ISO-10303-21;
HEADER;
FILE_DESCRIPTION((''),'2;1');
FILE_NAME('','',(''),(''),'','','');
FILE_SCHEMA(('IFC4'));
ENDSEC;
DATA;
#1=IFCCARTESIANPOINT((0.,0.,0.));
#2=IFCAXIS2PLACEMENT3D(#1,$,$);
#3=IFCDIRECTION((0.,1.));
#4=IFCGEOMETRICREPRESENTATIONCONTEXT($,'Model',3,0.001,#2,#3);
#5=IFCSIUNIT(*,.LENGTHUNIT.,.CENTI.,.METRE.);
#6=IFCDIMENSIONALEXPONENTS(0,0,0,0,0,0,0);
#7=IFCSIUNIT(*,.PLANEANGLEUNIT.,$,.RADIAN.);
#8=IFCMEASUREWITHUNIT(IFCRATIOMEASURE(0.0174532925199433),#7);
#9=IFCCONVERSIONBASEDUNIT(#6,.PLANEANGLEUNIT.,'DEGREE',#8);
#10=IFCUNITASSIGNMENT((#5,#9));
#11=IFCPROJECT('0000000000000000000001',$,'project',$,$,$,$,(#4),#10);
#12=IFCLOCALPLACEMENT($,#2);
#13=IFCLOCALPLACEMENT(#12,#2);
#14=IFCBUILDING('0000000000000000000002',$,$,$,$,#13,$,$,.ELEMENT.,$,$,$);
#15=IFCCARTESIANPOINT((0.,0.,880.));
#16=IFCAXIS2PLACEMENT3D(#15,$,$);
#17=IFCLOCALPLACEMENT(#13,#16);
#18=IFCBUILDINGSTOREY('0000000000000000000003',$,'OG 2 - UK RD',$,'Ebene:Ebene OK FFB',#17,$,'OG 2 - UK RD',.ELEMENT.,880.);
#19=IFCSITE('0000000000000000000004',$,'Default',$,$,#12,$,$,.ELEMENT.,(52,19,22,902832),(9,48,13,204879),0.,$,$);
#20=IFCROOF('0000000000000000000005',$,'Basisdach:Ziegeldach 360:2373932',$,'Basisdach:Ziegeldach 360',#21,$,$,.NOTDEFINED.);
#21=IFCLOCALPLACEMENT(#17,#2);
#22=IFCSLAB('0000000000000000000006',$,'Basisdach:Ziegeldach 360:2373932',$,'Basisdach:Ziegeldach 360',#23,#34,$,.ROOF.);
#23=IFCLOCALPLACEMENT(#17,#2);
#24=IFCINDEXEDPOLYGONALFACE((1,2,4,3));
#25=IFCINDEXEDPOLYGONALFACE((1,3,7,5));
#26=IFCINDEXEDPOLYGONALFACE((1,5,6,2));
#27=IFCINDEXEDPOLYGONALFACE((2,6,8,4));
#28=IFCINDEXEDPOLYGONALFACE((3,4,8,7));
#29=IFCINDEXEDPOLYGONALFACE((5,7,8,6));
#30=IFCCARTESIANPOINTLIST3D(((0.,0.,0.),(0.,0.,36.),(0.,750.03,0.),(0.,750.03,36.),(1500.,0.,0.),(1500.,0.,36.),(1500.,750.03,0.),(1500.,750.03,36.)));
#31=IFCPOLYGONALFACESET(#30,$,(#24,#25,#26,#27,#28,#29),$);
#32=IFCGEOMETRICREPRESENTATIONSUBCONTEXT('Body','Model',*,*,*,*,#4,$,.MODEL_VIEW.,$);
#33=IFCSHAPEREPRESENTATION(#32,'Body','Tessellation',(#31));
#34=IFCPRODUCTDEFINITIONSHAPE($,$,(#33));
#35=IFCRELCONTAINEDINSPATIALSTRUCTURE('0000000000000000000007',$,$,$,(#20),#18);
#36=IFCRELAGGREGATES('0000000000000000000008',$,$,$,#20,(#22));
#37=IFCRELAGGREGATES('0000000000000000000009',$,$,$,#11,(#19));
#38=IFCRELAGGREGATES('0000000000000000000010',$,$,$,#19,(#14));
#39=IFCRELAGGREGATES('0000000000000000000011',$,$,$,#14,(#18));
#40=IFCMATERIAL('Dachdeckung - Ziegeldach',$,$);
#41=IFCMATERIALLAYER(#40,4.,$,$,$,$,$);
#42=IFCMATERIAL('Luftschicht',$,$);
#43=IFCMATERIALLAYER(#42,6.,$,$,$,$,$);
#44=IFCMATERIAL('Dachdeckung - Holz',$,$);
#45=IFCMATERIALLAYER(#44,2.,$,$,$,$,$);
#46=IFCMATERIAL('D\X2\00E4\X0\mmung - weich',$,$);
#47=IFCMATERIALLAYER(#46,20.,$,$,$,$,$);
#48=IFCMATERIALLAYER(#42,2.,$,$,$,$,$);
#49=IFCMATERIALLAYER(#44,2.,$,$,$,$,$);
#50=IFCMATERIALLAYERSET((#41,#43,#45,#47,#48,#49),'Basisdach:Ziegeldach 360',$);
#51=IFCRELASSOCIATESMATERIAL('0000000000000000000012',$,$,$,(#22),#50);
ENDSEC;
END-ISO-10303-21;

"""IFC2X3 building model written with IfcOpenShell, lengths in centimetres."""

from ifc_helpers import new_model, entity, si_unit, converted_unit, direction, frame, origin, origin_2d_with_axis, place, context, subcontext, project, spatial, rectangle, extrude, material, layer, layer_set, element, aggregate, save


model = new_model("IFC2X3")

# Units and contexts
model_context = context("Model", 3, precision=0.001, world=origin(), true_north=direction((0.0, 1.0)))
body_context = subcontext(model_context, "Body", "Model", "MODEL_VIEW")
ifc_project = project(units=[si_unit("LENGTHUNIT", "METRE", prefix="CENTI"), converted_unit("PLANEANGLEUNIT", "DEGREE", entity("IfcRatioMeasure", 0.0174532925199433), si_unit("PLANEANGLEUNIT", "RADIAN"), dimensions=[0, 0, 0, 0, 0, 0, 0])], contexts=[model_context])

# Site, building, storey
site_placement = place(None, frame((0.0, 0.0, 0.0)))
site = spatial("IfcSite", under=ifc_project, at=site_placement, Name="Default", CompositionType="ELEMENT", RefLatitude=(52, 19, 22, 902832), RefLongitude=(9, 48, 13, 204879), RefElevation=0.0)
building_placement = place(site_placement, origin())
building = spatial("IfcBuilding", under=site, at=building_placement, CompositionType="ELEMENT")
storey_placement = place(building_placement, frame((0.0, 0.0, 880.0)))
storey = spatial("IfcBuildingStorey", under=building, at=storey_placement, Name="OG 2 - UK RD", ObjectType="Ebene:Ebene OK FFB", LongName="OG 2 - UK RD", CompositionType="ELEMENT", Elevation=880.0)

# Roof, slab
roof_placement = place(storey_placement, origin())
roof = element("IfcRoof", 1, at=roof_placement, inside=storey, Name="Basisdach:Ziegeldach 360:2373932", ObjectType="Basisdach:Ziegeldach 360", ShapeType="NOTDEFINED")
ifc_material_1 = material(Name="Dachdeckung - Ziegeldach")
ifc_layer_1 = layer(ifc_material_1, 4.0)
ifc_material_2 = material(Name="Luftschicht")
ifc_layer_2 = layer(ifc_material_2, 6.0)
ifc_material_3 = material(Name="Dachdeckung - Holz")
ifc_layer_3 = layer(ifc_material_3, 2.0)
ifc_material_4 = material(Name="Dämmung - weich")
ifc_layer_4 = layer(ifc_material_4, 20.0)
ifc_layer_5 = layer(ifc_material_2, 2.0)
ifc_layer_6 = layer(ifc_material_3, 2.0)
ifc_layer_set = layer_set([ifc_layer_1, ifc_layer_2, ifc_layer_3, ifc_layer_4, ifc_layer_5, ifc_layer_6], Name="Basisdach:Ziegeldach 360")
slab_placement = place(roof_placement, origin())
slab = element("IfcSlab", 2, at=slab_placement, material=ifc_layer_set, Name="Basisdach:Ziegeldach 360:2373932", ObjectType="Basisdach:Ziegeldach 360", PredefinedType="ROOF", context=body_context, shape_type="SweptSolid", body=[
    extrude(rectangle(XDim=1500.0, YDim=750.03, at=origin_2d_with_axis()), frame((750.0, 375.02, 0.0)), (0.0, 0.0, 1.0), 36.0),
])
aggregate(roof, [slab])

save(model, "model.ifc")
